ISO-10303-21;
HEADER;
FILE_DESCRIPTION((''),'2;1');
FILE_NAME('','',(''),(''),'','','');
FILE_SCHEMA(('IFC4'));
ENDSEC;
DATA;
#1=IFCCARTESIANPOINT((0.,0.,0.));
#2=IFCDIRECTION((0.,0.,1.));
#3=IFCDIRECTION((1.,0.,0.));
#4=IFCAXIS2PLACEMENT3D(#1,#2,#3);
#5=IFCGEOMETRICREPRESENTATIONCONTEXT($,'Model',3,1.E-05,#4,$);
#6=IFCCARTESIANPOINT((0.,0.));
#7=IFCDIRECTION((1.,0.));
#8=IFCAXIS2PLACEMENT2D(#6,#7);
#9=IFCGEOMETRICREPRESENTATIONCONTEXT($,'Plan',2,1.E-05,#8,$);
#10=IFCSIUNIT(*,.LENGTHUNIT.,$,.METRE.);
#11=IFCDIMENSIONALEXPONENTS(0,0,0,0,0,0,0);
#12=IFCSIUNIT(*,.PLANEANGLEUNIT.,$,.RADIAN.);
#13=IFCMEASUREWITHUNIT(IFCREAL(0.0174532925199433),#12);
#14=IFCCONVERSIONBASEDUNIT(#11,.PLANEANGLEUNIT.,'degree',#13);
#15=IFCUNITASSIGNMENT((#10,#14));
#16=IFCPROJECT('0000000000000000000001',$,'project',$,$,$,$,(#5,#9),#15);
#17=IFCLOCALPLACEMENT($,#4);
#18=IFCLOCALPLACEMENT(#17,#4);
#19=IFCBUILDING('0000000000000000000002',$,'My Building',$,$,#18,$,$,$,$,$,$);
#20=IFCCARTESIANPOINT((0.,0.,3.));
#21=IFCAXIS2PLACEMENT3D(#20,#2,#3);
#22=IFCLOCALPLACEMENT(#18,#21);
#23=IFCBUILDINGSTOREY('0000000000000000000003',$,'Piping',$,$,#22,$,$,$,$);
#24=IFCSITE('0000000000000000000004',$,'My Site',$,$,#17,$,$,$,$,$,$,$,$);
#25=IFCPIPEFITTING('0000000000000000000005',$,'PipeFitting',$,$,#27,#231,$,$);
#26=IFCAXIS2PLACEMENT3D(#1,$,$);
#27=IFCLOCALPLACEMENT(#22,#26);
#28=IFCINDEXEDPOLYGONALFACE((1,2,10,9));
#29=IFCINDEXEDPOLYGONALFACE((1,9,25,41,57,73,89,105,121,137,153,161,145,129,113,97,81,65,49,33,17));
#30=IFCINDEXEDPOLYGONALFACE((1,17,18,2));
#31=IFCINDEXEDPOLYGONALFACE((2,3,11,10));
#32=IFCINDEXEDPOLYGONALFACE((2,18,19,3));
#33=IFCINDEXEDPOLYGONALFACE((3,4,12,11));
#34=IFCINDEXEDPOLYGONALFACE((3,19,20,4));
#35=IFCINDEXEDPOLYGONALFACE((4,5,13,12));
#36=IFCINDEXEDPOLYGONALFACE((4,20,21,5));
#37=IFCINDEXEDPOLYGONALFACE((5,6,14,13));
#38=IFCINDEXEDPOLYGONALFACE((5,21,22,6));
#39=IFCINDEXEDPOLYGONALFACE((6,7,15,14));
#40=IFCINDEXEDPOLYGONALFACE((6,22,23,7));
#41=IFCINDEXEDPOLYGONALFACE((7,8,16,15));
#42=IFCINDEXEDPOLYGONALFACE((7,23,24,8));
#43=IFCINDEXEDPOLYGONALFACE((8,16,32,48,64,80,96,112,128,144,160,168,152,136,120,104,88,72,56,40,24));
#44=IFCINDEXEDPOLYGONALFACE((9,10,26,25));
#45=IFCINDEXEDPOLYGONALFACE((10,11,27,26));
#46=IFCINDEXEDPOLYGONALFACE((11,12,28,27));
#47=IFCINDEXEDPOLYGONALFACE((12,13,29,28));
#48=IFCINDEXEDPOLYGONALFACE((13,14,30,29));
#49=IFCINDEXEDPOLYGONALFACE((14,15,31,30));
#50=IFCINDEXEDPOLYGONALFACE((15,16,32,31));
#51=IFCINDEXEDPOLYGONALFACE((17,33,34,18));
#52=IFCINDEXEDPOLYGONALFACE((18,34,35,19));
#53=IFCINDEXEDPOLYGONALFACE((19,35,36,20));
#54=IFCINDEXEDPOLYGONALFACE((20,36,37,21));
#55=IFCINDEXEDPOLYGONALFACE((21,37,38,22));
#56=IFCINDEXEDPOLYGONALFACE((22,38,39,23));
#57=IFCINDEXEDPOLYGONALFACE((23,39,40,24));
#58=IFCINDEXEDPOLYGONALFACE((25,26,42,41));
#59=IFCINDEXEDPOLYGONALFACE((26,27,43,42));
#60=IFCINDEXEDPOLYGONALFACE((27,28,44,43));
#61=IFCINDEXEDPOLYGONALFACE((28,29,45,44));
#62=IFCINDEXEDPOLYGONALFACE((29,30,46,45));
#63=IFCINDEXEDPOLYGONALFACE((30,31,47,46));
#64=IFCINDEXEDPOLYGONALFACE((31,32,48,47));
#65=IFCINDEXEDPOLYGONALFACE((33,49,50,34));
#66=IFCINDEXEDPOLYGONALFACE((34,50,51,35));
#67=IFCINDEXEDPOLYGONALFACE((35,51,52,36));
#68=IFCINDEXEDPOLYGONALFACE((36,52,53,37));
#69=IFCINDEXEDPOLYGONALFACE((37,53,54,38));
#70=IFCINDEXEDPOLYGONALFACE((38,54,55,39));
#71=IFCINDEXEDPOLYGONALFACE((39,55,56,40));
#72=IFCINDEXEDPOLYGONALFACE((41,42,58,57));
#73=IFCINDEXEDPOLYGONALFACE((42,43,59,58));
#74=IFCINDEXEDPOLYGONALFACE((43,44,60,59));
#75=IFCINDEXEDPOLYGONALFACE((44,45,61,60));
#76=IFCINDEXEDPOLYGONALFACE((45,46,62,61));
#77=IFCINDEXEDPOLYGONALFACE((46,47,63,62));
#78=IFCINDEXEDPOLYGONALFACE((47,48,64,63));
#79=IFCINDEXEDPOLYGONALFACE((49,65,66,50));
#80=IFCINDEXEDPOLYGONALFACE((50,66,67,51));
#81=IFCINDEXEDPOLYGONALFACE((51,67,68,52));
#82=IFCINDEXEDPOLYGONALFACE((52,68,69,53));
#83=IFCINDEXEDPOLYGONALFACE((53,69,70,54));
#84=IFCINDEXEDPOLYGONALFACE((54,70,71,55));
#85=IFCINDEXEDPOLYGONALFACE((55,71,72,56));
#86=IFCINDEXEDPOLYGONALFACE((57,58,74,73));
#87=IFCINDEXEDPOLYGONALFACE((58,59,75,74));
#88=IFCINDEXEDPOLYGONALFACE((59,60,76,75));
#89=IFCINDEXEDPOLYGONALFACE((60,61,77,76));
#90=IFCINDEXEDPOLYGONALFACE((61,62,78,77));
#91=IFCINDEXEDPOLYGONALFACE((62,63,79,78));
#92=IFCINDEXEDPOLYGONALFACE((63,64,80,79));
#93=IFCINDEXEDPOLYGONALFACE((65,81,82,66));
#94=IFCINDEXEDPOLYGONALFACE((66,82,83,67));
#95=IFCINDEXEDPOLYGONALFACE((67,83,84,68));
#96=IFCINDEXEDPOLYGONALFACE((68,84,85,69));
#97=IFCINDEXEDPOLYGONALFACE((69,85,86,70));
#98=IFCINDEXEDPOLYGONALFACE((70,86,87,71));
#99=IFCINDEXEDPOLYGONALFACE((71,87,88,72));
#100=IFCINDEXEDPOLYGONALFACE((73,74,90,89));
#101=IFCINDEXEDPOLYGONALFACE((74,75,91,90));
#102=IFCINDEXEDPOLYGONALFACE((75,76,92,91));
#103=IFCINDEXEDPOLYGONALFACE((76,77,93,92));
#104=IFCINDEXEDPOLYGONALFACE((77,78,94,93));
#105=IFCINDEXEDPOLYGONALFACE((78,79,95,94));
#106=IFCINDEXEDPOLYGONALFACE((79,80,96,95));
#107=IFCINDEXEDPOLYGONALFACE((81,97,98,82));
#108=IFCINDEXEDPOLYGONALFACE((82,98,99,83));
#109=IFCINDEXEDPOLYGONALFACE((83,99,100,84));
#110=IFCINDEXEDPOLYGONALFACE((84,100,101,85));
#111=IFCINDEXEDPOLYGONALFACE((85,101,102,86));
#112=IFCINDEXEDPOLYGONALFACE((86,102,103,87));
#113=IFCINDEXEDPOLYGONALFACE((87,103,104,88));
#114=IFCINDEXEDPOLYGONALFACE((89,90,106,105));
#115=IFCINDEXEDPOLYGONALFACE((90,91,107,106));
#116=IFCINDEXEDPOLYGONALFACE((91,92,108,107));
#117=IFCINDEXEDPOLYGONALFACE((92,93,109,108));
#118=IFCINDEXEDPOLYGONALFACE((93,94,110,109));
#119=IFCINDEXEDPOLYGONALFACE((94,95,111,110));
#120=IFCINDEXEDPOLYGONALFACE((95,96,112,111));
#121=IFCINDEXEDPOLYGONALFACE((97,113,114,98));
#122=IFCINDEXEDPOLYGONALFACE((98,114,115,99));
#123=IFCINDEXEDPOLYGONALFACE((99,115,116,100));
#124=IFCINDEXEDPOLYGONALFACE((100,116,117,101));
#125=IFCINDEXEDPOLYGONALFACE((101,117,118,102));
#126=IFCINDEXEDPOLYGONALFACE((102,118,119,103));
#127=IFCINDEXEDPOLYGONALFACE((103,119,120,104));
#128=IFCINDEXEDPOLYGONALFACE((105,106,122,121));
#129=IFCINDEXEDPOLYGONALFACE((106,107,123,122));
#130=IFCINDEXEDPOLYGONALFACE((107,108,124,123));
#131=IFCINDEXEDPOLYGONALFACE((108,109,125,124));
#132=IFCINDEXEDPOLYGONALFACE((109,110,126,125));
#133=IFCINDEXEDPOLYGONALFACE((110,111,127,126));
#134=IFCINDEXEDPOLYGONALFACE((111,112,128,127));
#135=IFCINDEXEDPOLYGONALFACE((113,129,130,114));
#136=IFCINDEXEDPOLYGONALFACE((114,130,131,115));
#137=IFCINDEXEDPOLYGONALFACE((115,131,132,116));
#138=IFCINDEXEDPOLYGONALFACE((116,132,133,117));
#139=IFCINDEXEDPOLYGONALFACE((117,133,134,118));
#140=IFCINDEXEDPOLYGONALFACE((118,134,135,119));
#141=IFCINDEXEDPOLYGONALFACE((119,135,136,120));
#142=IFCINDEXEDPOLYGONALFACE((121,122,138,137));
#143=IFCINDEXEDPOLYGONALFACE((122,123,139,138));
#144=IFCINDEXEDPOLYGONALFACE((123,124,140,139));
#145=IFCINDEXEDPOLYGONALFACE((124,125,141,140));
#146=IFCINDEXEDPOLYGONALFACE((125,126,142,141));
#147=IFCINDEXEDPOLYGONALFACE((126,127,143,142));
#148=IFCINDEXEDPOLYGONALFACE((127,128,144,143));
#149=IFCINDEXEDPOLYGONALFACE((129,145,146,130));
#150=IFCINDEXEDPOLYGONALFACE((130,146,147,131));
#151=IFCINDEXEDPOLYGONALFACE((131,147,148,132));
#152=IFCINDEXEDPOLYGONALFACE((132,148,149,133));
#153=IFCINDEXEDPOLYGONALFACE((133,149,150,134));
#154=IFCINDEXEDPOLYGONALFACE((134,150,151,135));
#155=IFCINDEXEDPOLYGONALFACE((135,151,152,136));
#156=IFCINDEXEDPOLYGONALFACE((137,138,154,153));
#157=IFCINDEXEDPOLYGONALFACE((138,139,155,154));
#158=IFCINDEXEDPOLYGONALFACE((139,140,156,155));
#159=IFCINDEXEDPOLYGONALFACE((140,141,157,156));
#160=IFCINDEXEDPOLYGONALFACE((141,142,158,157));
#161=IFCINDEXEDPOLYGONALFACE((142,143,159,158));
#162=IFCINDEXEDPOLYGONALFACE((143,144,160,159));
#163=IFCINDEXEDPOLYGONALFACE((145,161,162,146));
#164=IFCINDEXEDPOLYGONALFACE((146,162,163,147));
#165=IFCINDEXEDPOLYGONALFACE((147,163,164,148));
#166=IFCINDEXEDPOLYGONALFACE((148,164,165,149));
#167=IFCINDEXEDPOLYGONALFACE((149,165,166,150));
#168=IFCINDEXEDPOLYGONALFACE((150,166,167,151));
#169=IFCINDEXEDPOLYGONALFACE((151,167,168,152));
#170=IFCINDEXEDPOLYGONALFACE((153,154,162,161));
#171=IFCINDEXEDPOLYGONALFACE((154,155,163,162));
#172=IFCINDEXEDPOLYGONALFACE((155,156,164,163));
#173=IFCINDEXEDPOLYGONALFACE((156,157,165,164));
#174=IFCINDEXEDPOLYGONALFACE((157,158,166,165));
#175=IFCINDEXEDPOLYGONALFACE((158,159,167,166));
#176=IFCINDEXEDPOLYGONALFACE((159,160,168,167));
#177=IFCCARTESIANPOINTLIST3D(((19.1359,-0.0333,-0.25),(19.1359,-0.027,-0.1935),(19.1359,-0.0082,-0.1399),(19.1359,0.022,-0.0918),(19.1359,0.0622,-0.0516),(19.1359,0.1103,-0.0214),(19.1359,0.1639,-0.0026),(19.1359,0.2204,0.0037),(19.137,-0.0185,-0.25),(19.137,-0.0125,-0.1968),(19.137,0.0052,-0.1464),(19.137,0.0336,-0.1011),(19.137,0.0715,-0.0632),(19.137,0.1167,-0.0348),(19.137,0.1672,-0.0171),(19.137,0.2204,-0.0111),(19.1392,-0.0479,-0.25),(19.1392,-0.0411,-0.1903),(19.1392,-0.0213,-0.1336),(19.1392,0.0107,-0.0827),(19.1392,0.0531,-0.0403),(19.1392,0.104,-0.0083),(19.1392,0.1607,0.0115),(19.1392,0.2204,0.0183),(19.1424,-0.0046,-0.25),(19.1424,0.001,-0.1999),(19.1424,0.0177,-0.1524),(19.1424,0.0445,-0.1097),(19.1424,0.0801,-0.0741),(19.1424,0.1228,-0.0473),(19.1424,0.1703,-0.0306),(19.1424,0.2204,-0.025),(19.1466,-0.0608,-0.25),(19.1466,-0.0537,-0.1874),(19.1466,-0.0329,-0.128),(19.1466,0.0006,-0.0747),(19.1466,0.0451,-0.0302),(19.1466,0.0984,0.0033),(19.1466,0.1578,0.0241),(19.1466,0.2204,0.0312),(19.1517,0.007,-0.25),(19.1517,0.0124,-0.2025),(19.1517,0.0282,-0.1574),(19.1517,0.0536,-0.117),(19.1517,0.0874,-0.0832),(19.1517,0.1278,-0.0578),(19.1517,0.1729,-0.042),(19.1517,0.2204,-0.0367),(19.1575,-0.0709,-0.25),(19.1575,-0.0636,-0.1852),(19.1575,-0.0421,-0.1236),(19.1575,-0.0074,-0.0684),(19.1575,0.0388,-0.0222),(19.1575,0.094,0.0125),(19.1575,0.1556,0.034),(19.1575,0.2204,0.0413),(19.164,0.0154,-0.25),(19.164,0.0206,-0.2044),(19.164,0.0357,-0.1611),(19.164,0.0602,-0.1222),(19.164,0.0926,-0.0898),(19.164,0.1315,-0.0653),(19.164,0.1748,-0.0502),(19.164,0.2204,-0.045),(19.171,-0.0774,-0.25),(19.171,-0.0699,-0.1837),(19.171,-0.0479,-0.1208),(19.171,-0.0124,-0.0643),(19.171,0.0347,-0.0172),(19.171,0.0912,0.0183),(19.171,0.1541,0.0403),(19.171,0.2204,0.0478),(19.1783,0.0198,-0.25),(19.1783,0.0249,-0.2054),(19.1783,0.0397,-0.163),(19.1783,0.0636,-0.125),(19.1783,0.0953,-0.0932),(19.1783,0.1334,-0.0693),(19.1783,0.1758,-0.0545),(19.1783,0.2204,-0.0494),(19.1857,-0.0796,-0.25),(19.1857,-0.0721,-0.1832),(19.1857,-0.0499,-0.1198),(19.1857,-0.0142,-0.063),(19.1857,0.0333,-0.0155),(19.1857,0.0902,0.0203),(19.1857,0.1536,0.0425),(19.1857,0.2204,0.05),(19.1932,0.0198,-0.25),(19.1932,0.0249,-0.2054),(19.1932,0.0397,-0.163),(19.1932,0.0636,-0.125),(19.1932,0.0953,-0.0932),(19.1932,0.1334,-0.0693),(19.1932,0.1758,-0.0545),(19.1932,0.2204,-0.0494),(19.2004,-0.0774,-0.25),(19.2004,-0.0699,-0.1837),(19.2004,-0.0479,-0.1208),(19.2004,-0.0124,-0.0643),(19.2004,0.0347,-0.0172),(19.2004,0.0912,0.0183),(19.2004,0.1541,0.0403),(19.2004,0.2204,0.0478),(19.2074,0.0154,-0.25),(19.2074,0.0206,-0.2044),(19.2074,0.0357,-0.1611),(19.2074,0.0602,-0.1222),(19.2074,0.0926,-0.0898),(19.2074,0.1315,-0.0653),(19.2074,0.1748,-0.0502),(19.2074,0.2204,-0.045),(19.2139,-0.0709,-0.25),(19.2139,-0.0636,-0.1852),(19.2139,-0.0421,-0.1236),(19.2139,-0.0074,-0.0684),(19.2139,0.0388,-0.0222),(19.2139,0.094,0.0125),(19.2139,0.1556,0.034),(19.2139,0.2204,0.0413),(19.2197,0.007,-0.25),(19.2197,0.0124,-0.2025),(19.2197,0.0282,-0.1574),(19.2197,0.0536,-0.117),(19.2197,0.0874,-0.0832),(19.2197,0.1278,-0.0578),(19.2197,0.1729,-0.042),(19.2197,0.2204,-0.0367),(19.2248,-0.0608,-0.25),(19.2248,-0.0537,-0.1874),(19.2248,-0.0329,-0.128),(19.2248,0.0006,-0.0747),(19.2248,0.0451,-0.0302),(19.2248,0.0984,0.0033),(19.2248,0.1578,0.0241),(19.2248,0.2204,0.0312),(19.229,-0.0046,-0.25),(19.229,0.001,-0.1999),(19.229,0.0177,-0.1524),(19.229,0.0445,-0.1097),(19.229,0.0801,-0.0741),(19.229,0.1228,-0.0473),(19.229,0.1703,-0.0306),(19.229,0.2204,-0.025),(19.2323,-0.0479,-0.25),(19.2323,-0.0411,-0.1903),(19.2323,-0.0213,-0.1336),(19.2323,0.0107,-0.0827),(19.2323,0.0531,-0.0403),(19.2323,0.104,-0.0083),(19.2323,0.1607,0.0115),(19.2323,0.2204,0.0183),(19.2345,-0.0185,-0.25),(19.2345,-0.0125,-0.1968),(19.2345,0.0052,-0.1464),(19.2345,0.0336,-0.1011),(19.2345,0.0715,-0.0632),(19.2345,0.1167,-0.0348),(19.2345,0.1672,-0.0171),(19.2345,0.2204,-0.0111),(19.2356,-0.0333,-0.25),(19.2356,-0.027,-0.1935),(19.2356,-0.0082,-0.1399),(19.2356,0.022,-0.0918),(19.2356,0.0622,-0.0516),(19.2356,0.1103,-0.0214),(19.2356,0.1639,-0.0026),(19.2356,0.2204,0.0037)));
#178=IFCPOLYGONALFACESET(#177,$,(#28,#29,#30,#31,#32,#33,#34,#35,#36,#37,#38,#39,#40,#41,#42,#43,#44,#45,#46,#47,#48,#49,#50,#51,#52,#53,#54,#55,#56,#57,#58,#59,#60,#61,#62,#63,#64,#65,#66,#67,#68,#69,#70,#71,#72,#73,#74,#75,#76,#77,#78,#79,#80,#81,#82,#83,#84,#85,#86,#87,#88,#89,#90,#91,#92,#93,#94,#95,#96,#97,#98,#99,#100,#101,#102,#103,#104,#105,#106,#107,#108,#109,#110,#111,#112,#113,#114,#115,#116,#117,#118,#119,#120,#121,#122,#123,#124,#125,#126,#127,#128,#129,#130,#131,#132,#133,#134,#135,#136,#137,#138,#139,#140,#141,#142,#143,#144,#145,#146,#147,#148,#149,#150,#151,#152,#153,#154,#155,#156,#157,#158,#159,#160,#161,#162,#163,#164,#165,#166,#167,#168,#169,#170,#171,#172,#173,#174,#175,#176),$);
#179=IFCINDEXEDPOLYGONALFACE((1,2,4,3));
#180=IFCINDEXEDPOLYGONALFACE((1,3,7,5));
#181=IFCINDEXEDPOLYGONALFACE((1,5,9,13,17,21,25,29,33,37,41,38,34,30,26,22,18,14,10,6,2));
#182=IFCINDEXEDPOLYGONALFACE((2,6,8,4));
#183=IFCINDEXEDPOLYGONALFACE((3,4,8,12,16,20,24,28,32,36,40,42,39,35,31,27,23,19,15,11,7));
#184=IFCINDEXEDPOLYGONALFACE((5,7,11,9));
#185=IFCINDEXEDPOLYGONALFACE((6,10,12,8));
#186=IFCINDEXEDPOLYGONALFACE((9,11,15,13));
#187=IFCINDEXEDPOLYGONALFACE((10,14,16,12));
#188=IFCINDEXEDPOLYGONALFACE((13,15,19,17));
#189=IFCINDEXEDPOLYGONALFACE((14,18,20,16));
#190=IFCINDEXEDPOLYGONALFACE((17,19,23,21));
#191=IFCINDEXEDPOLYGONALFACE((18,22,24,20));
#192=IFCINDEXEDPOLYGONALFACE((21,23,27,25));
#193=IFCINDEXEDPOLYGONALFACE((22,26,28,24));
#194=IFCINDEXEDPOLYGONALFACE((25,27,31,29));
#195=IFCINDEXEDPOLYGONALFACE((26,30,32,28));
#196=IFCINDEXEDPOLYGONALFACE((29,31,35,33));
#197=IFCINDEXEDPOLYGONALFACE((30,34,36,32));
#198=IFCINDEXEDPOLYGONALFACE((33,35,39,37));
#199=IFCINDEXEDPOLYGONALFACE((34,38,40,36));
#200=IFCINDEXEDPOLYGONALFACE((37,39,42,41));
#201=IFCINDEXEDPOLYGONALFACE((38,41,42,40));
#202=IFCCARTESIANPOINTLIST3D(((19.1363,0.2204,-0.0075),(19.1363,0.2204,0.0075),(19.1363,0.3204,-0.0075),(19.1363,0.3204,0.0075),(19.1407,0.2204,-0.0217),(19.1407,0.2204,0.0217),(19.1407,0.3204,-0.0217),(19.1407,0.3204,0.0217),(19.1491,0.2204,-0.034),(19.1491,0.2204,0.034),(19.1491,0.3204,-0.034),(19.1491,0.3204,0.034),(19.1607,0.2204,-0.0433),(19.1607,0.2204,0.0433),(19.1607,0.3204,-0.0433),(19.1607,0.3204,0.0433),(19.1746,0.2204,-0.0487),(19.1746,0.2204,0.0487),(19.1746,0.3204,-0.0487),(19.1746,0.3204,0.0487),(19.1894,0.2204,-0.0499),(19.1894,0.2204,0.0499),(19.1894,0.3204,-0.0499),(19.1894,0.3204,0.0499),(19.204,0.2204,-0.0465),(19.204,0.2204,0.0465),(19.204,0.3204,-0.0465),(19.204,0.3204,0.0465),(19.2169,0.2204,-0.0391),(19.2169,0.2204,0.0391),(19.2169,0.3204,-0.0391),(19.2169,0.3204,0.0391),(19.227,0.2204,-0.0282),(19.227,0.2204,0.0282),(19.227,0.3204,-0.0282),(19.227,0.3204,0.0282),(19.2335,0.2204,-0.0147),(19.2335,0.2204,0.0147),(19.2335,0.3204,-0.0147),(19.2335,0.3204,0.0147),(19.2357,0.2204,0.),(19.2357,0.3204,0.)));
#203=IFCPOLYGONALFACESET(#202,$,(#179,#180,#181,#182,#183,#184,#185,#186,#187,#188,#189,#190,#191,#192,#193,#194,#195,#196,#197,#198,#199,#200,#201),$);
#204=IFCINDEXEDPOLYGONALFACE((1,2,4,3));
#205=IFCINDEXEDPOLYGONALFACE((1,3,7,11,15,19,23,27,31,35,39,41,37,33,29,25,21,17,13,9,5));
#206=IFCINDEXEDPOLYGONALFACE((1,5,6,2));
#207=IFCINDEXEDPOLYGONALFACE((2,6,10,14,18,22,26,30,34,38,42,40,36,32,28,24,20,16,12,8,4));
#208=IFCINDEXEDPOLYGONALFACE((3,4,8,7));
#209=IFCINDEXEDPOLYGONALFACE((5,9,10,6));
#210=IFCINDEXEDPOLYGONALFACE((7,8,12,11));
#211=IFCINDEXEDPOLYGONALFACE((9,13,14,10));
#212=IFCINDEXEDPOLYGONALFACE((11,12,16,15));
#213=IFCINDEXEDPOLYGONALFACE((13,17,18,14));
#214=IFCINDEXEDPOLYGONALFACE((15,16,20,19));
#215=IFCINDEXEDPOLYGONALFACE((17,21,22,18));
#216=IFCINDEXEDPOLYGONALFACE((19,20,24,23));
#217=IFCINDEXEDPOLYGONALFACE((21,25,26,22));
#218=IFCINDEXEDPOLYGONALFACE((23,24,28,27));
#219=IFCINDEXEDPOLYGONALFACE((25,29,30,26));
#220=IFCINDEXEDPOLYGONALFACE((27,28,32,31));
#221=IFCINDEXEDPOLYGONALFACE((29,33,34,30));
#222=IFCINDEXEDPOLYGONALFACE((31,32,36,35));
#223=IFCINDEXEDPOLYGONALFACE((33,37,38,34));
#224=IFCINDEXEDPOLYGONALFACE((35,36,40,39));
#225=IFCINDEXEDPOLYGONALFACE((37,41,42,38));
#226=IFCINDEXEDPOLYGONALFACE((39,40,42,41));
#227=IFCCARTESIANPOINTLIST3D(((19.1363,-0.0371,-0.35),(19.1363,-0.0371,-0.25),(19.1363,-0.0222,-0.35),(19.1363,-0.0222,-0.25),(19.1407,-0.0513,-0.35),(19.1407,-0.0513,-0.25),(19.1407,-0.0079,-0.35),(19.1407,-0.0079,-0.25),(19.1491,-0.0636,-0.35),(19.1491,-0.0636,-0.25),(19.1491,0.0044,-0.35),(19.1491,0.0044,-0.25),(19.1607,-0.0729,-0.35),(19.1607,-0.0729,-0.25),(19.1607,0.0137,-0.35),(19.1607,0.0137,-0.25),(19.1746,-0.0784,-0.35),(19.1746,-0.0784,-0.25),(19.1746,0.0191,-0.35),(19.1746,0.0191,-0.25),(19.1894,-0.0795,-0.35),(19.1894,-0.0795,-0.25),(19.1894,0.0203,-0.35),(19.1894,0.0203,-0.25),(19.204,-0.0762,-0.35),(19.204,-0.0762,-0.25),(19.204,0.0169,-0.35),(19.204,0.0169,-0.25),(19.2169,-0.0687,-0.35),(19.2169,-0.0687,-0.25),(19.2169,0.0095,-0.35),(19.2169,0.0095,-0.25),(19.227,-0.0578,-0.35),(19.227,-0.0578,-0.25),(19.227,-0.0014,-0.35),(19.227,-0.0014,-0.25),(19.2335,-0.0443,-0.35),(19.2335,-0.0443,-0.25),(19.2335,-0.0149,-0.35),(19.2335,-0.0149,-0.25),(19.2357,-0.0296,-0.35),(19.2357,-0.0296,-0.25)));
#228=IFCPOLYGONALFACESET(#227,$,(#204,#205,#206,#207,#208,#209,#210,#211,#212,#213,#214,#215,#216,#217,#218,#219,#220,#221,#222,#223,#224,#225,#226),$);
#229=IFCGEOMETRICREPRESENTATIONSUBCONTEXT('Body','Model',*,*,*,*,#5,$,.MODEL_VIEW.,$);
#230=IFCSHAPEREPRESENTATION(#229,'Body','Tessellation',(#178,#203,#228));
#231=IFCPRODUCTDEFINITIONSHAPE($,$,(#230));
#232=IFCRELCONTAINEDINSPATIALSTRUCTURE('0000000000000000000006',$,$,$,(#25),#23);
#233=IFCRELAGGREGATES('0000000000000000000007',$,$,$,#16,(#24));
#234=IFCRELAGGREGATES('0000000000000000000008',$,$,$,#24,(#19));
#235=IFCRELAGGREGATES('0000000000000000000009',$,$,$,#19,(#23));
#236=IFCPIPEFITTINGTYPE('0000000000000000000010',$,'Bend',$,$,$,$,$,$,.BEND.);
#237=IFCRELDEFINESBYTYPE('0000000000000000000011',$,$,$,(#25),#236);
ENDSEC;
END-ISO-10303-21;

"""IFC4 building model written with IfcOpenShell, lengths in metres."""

from ifc_helpers import new_model, entity, si_unit, converted_unit, frame, origin_with_axes, origin_2d_with_axis, place, context, subcontext, project, spatial, line, indexed_curve, circle, outline, extrude, source, transform, mapped, type_object, type_shapes, element, save


model = new_model("IFC4")

# Units and contexts
model_context = context("Model", 3, precision=1e-05, world=origin_with_axes())
plan_context = context("Plan", 2, precision=1e-05, world=origin_2d_with_axis())
body_context = subcontext(model_context, "Body", "Model", "MODEL_VIEW")
ifc_project = project(units=[si_unit("LENGTHUNIT", "METRE"), converted_unit("PLANEANGLEUNIT", "degree", entity("IfcReal", 0.0174532925199433), si_unit("PLANEANGLEUNIT", "RADIAN"), dimensions=[0, 0, 0, 0, 0, 0, 0])], contexts=[model_context, plan_context])

# Site, building, storey
site_placement = place(None, origin_with_axes())
site = spatial("IfcSite", under=ifc_project, at=site_placement, Name="My Site")
building_placement = place(site_placement, origin_with_axes())
building = spatial("IfcBuilding", under=site, at=building_placement, Name="My Building")
storey_placement = place(building_placement, frame((0.0, 0.0, 3.0), z_axis=(0.0, 0.0, 1.0), x_axis=(1.0, 0.0, 0.0)))
storey = spatial("IfcBuildingStorey", under=building, at=storey_placement, Name="Piping")

# Pipe fitting, opening
pipe_fitting_type = type_object("IfcPipeFittingType", Name="Bend", PredefinedType="BEND")
shared_shape = source(origin_with_axes(), body_context, "Body", "SolidModel", [
    entity("IfcSweptDiskSolid", entity("IfcIndexedPolyCurve", entity("IfcCartesianPointList3D", [[0.0, 0.0, 0.1], [0.0, -0.0732, 0.2768], [0.0, -0.25, 0.35]]), [entity("IfcArcIndex", [1, 2, 3])]), 0.05),
    extrude(circle(Radius=0.05), origin_with_axes(), (0.0, 0.0, 1.0), 0.1),
    extrude(circle(Radius=0.05), frame((0.0, -0.25, 0.35), z_axis=(0.0, -1.0, 0.0), x_axis=(1.0, 0.0, 0.0)), (0.0, 0.0, 1.0), 0.1),
])
type_shapes(pipe_fitting_type, [shared_shape])
pipe_fitting_1_placement = place(storey_placement, frame((19.1857, 0.3204, 0.0), z_axis=(0.0, -1.0, 0.0), x_axis=(1.0, 0.0, 0.0)))
pipe_fitting_1 = element("IfcPipeFitting", 1, at=pipe_fitting_1_placement, inside=storey, type_object=pipe_fitting_type, Name="PipeFitting", context=body_context, shape_type="MappedRepresentation", body=[
    mapped(shared_shape, transform((0.0, 0.0, 0.0), x_axis=(1.0, 0.0, 0.0), y_axis=(0.0, 1.0, 0.0), z_axis=(0.0, 0.0, 1.0), scale=1.0)),
])
opening_1_placement = place(pipe_fitting_1_placement, frame((-19.1857, -3.0, 0.3204), z_axis=(0.0, 1.0, 0.0), x_axis=(1.0, 0.0, 0.0)))
element("IfcOpeningElement", 2, at=opening_1_placement, cuts=pipe_fitting_1, PredefinedType="OPENING", context=body_context, shape_type="SweptSolid", body=[
    extrude(outline(indexed_curve([(0.0, 0.0), (0.5, 0.0), (0.5, 0.5), (0.0, 0.5)], segments=[line(1, 2, 3, 4, 1)])), origin_with_axes(), (0.0, 0.0, 1.0), 0.5),
])

save(model, "model.ifc")
